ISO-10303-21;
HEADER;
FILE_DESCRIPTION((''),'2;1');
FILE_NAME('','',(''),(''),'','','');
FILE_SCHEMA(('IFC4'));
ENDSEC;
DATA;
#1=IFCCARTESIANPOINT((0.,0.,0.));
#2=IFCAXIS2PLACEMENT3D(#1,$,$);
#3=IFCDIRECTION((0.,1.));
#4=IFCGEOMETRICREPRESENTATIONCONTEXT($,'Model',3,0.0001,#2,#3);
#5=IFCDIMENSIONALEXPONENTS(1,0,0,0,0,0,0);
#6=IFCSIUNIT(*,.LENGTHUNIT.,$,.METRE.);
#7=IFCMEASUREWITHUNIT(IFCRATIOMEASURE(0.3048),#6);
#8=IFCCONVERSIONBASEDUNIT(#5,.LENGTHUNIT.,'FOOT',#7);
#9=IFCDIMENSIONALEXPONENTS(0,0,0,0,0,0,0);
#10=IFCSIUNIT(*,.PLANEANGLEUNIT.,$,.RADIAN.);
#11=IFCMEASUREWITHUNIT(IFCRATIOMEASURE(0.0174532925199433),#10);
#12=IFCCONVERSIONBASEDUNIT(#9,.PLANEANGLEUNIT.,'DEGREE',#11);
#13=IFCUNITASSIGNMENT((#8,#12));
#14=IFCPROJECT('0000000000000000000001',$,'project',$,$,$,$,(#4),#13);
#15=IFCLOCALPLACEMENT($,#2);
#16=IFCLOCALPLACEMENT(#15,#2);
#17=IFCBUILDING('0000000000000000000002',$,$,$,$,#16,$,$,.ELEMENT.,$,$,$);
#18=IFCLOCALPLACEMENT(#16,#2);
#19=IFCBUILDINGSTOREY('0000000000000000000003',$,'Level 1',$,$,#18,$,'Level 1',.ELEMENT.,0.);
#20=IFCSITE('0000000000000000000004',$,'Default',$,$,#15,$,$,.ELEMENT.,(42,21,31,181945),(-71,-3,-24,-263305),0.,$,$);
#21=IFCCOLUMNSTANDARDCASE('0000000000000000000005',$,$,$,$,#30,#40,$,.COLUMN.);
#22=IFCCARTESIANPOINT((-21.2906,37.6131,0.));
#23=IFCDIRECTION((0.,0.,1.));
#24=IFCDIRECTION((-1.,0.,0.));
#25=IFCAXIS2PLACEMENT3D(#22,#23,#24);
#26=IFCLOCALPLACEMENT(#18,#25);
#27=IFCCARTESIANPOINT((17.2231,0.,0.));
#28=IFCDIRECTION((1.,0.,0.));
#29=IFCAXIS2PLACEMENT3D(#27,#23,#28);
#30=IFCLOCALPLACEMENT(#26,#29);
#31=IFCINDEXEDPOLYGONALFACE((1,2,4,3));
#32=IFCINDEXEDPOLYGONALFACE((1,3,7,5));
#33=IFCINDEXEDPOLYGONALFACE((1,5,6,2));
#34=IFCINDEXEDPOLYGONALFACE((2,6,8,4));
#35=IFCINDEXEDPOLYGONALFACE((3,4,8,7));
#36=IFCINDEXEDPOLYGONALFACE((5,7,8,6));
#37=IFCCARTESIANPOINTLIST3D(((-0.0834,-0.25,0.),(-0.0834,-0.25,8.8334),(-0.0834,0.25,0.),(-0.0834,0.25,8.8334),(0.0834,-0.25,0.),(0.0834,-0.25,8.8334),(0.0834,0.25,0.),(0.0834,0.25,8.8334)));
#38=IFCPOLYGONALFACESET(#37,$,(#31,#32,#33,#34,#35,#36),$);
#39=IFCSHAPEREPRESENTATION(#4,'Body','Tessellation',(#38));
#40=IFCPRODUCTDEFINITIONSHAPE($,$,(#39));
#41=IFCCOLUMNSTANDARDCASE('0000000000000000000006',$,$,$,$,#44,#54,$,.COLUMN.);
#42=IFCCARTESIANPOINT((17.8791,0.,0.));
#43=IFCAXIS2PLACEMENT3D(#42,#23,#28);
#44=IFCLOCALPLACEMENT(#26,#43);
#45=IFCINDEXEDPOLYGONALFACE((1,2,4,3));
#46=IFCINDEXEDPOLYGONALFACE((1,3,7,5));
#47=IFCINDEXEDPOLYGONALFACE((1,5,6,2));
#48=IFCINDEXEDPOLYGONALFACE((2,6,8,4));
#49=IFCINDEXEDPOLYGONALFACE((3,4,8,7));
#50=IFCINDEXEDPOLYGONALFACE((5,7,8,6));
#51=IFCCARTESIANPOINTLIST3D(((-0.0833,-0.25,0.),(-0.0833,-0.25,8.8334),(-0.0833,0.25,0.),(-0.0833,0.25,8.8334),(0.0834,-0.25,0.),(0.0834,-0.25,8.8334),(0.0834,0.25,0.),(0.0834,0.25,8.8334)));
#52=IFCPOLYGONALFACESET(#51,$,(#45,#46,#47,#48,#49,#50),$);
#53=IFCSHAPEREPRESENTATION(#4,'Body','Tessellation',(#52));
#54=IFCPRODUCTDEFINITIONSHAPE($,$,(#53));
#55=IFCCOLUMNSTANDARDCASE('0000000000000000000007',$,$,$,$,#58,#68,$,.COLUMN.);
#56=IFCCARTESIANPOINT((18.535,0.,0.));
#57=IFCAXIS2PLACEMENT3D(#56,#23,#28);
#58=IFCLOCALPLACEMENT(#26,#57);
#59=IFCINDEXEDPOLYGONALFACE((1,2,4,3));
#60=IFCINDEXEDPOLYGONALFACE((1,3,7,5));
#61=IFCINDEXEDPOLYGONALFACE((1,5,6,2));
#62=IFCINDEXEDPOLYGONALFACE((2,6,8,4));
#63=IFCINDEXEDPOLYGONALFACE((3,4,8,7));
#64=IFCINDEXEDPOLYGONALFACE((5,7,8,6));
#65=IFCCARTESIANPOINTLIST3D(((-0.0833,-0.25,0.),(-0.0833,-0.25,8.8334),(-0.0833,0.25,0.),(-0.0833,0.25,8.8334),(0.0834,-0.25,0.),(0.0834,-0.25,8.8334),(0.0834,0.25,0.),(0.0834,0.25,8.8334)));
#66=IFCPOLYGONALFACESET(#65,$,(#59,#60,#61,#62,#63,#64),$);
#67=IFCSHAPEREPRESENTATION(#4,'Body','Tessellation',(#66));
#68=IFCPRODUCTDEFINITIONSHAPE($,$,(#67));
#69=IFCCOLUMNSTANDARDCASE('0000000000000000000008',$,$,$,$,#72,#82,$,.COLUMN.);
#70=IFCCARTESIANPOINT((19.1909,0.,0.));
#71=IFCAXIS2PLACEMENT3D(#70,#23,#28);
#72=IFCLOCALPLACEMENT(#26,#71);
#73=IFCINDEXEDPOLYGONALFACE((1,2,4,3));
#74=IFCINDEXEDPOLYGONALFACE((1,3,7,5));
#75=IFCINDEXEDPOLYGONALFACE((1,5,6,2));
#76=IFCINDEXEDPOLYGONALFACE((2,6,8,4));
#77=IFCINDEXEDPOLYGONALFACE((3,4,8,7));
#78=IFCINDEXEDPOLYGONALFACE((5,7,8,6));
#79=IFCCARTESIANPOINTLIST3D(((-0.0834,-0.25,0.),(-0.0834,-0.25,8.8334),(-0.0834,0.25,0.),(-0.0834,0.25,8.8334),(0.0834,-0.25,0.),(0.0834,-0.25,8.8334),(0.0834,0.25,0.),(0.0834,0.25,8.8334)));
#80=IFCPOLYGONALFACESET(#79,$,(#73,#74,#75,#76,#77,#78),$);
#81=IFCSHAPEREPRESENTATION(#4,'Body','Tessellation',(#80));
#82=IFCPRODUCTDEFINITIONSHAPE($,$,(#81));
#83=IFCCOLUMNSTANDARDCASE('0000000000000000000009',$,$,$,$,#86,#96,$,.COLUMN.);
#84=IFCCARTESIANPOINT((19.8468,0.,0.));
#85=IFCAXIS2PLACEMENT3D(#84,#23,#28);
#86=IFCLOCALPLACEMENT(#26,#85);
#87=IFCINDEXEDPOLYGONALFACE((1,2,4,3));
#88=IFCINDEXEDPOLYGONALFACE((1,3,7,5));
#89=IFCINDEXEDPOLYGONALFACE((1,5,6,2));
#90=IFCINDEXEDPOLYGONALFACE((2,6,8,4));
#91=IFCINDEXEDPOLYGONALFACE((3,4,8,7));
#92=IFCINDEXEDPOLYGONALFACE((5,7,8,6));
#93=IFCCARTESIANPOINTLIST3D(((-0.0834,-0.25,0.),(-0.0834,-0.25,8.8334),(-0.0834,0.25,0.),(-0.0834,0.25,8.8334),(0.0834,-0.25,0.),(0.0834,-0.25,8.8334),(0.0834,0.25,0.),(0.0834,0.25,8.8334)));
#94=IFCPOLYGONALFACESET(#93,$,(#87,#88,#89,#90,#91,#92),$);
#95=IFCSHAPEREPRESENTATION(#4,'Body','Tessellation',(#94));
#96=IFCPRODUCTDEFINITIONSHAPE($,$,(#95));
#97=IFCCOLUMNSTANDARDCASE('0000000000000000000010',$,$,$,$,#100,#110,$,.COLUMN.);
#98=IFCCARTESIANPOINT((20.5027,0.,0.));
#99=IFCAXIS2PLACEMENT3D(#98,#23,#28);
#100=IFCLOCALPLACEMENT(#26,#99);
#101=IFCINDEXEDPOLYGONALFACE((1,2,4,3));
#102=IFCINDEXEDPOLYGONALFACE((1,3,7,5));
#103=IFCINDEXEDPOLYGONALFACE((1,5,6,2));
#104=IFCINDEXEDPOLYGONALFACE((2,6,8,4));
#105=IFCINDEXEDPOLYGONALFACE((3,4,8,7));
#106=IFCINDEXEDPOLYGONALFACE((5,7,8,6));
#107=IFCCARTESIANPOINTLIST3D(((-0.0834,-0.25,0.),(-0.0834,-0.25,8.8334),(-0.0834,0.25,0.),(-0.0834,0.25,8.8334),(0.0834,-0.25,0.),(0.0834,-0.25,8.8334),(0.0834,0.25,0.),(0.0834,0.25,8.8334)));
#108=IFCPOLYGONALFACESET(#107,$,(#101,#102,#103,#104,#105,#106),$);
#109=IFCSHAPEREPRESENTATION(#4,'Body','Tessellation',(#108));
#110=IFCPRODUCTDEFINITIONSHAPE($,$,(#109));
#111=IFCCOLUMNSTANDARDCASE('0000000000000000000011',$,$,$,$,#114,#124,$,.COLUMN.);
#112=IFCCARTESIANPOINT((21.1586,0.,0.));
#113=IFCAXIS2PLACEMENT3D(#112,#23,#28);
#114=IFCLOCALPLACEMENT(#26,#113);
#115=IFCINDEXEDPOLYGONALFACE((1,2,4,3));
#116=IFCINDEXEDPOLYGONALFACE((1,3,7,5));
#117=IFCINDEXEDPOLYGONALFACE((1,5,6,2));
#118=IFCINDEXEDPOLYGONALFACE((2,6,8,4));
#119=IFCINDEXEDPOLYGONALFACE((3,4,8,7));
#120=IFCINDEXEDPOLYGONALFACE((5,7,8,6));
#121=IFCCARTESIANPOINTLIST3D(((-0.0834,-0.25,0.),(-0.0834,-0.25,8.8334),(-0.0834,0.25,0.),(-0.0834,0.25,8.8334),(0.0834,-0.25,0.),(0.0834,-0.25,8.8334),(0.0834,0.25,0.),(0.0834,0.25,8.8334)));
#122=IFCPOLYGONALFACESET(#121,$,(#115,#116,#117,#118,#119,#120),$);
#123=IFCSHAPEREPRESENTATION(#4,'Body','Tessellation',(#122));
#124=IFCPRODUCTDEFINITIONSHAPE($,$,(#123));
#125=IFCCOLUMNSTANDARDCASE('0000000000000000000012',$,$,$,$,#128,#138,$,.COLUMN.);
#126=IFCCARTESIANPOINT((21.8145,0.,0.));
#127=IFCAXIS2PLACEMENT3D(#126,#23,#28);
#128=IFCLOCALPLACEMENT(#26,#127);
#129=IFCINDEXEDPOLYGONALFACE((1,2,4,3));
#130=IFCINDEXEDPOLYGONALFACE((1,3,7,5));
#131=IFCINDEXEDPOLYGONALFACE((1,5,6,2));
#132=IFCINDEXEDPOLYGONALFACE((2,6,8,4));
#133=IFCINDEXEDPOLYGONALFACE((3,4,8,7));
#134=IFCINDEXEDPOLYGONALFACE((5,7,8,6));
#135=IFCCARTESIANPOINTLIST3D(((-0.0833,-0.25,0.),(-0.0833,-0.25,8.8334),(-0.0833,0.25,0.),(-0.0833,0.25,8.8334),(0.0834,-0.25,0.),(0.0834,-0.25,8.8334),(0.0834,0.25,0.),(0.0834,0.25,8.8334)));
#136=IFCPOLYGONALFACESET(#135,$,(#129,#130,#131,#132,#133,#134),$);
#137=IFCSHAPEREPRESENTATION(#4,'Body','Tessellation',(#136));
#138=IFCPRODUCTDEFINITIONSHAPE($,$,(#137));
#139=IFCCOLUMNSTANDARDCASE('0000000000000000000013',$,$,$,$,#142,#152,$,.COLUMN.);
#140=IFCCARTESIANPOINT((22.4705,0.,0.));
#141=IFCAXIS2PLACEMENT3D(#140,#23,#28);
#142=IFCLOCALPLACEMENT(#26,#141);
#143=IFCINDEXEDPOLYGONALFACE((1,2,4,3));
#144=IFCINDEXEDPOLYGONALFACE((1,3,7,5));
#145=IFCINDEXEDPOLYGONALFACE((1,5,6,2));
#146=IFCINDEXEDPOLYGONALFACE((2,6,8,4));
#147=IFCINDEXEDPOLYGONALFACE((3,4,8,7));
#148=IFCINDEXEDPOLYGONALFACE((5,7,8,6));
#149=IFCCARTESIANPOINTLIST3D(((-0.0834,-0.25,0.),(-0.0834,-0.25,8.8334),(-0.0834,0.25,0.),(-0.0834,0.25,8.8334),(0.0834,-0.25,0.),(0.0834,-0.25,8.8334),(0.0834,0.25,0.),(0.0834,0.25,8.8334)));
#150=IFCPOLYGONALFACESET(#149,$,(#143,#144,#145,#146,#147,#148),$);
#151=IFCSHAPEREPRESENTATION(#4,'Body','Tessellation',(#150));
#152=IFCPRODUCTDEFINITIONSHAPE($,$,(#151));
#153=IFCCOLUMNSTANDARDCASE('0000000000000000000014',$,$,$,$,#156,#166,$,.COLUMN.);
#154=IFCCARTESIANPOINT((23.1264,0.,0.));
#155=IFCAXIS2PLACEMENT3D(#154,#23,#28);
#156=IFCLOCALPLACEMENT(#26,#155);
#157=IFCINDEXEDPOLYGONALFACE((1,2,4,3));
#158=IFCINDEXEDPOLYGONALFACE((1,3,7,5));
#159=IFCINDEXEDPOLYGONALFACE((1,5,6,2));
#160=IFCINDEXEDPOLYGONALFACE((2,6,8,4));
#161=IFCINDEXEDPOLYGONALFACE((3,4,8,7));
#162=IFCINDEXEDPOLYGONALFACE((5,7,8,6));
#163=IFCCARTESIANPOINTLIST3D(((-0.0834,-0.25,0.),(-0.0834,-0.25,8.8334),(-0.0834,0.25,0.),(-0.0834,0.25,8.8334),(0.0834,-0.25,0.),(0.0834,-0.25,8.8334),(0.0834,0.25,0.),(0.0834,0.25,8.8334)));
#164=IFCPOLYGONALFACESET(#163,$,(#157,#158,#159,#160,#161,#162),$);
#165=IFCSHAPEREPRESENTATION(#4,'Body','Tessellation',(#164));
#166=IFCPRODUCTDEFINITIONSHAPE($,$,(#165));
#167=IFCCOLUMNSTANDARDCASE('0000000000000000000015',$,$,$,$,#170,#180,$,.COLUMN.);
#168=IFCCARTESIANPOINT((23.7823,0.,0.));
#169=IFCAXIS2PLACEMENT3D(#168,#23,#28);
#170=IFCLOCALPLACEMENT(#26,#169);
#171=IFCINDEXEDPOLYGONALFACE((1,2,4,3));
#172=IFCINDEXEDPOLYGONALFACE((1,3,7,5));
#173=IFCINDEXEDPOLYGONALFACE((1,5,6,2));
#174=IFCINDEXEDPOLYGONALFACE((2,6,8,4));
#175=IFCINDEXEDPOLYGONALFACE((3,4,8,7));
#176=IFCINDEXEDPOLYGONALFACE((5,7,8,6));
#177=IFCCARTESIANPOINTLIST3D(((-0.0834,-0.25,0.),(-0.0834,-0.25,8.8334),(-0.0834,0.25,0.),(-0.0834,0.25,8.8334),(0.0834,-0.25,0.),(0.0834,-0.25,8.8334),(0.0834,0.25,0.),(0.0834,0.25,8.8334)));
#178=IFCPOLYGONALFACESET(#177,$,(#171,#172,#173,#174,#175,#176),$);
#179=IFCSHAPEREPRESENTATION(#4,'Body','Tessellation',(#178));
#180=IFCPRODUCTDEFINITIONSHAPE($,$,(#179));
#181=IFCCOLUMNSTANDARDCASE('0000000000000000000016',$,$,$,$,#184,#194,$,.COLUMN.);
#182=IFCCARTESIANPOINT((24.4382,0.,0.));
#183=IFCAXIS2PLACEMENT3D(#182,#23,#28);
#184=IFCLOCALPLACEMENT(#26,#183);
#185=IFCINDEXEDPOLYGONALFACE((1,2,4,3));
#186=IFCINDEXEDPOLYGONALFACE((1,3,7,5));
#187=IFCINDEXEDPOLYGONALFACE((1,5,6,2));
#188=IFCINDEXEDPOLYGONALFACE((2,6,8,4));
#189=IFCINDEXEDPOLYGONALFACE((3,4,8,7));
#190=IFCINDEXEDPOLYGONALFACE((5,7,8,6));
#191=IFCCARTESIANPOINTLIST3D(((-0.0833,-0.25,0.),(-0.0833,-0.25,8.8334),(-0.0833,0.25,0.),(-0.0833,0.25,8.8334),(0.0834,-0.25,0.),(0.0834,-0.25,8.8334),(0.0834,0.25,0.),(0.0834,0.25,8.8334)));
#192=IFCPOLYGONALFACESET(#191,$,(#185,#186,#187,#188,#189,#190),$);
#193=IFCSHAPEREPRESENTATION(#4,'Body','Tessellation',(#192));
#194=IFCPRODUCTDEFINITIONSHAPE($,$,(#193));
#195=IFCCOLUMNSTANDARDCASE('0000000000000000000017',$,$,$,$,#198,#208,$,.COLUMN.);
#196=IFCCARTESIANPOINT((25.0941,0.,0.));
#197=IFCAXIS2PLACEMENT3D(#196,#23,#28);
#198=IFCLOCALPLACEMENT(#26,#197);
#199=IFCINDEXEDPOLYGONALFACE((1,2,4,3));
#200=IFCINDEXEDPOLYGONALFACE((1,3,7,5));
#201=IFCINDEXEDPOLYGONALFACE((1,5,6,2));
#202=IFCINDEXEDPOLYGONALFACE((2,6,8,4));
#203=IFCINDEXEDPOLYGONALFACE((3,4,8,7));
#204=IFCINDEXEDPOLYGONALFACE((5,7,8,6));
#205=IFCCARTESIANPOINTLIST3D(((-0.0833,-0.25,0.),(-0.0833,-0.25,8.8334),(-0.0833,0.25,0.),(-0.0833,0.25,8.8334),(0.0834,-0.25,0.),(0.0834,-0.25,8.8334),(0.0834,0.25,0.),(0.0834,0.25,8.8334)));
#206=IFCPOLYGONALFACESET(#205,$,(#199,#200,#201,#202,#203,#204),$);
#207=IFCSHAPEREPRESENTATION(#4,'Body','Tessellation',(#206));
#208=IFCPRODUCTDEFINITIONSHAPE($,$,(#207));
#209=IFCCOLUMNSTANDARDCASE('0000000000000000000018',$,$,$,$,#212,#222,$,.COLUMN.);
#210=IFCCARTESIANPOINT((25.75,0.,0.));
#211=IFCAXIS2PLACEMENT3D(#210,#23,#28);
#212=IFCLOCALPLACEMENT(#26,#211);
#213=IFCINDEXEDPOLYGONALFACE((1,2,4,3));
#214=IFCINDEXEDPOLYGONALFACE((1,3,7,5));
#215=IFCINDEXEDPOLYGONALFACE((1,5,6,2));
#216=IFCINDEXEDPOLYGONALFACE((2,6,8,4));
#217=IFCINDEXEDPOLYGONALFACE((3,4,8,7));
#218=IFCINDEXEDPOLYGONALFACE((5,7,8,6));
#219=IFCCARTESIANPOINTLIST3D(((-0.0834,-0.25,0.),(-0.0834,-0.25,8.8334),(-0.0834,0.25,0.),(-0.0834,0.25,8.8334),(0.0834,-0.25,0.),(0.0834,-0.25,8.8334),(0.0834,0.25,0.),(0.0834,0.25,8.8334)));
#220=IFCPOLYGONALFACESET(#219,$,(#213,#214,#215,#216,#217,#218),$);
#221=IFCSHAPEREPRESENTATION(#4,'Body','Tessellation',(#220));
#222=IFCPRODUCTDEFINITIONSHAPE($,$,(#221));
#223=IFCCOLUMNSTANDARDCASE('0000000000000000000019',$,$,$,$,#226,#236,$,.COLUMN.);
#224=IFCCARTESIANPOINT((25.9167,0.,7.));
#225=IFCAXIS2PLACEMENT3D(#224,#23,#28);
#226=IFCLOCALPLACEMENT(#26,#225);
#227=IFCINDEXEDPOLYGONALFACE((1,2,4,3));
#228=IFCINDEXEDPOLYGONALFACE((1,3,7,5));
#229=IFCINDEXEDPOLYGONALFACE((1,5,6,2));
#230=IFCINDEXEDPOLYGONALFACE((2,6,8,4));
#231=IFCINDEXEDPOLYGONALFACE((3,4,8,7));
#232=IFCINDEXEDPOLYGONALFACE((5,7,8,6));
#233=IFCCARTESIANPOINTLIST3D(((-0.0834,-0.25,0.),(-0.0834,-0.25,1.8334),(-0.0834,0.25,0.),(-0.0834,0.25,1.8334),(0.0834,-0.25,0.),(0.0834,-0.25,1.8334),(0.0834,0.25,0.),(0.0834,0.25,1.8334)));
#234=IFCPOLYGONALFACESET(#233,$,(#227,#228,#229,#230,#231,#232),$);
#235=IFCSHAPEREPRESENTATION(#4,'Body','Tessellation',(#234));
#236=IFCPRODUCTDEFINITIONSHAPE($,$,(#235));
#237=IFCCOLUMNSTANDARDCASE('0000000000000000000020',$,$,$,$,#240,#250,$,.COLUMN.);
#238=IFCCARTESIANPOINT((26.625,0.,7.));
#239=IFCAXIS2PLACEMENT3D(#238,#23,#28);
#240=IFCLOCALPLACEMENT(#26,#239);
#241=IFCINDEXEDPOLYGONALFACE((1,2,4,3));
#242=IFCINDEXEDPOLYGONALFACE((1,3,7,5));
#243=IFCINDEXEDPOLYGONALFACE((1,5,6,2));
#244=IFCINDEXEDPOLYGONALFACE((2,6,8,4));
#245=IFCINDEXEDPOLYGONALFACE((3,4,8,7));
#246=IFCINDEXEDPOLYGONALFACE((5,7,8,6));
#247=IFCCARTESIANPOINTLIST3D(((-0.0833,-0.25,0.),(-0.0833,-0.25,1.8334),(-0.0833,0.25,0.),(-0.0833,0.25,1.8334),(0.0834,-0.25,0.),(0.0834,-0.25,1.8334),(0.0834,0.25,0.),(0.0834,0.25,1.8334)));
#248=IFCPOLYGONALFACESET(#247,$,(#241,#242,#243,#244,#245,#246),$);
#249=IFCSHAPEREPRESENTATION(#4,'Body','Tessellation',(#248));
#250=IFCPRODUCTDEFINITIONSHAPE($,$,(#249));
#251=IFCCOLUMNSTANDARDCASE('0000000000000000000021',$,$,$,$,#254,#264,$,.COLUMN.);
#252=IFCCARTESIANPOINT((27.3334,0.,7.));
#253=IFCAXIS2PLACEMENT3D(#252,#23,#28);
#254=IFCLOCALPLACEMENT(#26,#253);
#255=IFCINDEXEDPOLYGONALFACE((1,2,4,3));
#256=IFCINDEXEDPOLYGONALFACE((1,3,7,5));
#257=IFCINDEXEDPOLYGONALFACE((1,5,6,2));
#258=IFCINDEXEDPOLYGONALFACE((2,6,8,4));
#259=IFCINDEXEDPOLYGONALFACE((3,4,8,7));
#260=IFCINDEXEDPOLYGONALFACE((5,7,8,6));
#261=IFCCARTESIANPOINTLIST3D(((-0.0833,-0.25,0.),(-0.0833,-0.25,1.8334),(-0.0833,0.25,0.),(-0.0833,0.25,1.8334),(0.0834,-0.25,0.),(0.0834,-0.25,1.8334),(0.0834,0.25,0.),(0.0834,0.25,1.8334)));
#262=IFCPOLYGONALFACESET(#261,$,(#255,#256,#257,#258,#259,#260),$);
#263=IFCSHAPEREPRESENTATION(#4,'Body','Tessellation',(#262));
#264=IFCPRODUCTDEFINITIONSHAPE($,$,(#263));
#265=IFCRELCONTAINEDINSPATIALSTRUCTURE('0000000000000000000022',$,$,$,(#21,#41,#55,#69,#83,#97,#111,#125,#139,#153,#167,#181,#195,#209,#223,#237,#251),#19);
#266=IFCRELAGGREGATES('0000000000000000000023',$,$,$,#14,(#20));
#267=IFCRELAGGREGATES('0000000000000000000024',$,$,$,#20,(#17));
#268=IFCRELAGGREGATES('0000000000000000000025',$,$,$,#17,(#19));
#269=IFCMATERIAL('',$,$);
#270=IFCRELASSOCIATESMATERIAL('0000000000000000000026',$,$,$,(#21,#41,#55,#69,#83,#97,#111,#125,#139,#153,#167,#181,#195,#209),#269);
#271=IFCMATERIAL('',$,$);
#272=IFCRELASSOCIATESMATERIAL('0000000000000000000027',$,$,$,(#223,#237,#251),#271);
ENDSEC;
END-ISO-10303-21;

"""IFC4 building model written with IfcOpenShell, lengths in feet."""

from ifc_helpers import new_model, entity, si_unit, converted_unit, direction, frame, origin, place, context, project, spatial, rectangle, extrude, material, element, save


model = new_model("IFC4")

# Units and contexts
model_context = context("Model", 3, precision=0.0001, world=origin(), true_north=direction((0.0, 1.0)))
ifc_project = project(units=[converted_unit("LENGTHUNIT", "FOOT", entity("IfcRatioMeasure", 0.3048), si_unit("LENGTHUNIT", "METRE"), dimensions=[1, 0, 0, 0, 0, 0, 0]), converted_unit("PLANEANGLEUNIT", "DEGREE", entity("IfcRatioMeasure", 0.0174532925199433), si_unit("PLANEANGLEUNIT", "RADIAN"), dimensions=[0, 0, 0, 0, 0, 0, 0])], contexts=[model_context])

# Site, building, storey
site_placement = place(None, origin())
site = spatial("IfcSite", under=ifc_project, at=site_placement, Name="Default", CompositionType="ELEMENT", RefLatitude=(42, 21, 31, 181945), RefLongitude=(-71, -3, -24, -263305), RefElevation=0.0)
building_placement = place(site_placement, origin())
building = spatial("IfcBuilding", under=site, at=building_placement, CompositionType="ELEMENT")
storey_placement = place(building_placement, origin())
storey = spatial("IfcBuildingStorey", under=building, at=storey_placement, Name="Level 1", LongName="Level 1", CompositionType="ELEMENT", Elevation=0.0)

# Columns
ifc_material_1 = material(Name="")
ifc_material_2 = material(Name="")
placement_1 = place(storey_placement, frame((-21.2906, 37.6131, 0.0), z_axis=(0.0, 0.0, 1.0), x_axis=(-1.0, 0.0, 0.0)))
for number, where, z_axis, x_axis in (
    (1, (17.2231, 0.0, 0.0), (0.0, 0.0, 1.0), (1.0, 0.0, 0.0)),
    (2, (17.8791, 0.0, 0.0), (0.0, 0.0, 1.0), (1.0, 0.0, 0.0)),
    (3, (18.535, 0.0, 0.0), (0.0, 0.0, 1.0), (1.0, 0.0, 0.0)),
    (4, (19.1909, 0.0, 0.0), (0.0, 0.0, 1.0), (1.0, 0.0, 0.0)),
    (5, (19.8468, 0.0, 0.0), (0.0, 0.0, 1.0), (1.0, 0.0, 0.0)),
    (6, (20.5027, 0.0, 0.0), (0.0, 0.0, 1.0), (1.0, 0.0, 0.0)),
    (7, (21.1586, 0.0, 0.0), (0.0, 0.0, 1.0), (1.0, 0.0, 0.0)),
    (8, (21.8145, 0.0, 0.0), (0.0, 0.0, 1.0), (1.0, 0.0, 0.0)),
    (9, (22.4705, 0.0, 0.0), (0.0, 0.0, 1.0), (1.0, 0.0, 0.0)),
    (10, (23.1264, 0.0, 0.0), (0.0, 0.0, 1.0), (1.0, 0.0, 0.0)),
    (11, (23.7823, 0.0, 0.0), (0.0, 0.0, 1.0), (1.0, 0.0, 0.0)),
    (12, (24.4382, 0.0, 0.0), (0.0, 0.0, 1.0), (1.0, 0.0, 0.0)),
    (13, (25.0941, 0.0, 0.0), (0.0, 0.0, 1.0), (1.0, 0.0, 0.0)),
    (14, (25.75, 0.0, 0.0), (0.0, 0.0, 1.0), (1.0, 0.0, 0.0)),
):
    element("IfcColumnStandardCase", number, at=place(placement_1, frame(where, z_axis=z_axis, x_axis=x_axis)), inside=storey, material=ifc_material_1, PredefinedType="COLUMN", context=model_context, shape_type="SweptSolid", body=[
        extrude(rectangle(XDim=0.1667, YDim=0.5), origin(), (0.0, 0.0, 1.0), 8.8334),
    ])
for number, where, z_axis, x_axis in (
    (15, (25.9167, 0.0, 7.0), (0.0, 0.0, 1.0), (1.0, 0.0, 0.0)),
    (16, (26.625, 0.0, 7.0), (0.0, 0.0, 1.0), (1.0, 0.0, 0.0)),
    (17, (27.3334, 0.0, 7.0), (0.0, 0.0, 1.0), (1.0, 0.0, 0.0)),
):
    element("IfcColumnStandardCase", number, at=place(placement_1, frame(where, z_axis=z_axis, x_axis=x_axis)), inside=storey, material=ifc_material_2, PredefinedType="COLUMN", context=model_context, shape_type="SweptSolid", body=[
        extrude(rectangle(XDim=0.1667, YDim=0.5), origin(), (0.0, 0.0, 1.0), 1.8334),
    ])

save(model, "model.ifc")
